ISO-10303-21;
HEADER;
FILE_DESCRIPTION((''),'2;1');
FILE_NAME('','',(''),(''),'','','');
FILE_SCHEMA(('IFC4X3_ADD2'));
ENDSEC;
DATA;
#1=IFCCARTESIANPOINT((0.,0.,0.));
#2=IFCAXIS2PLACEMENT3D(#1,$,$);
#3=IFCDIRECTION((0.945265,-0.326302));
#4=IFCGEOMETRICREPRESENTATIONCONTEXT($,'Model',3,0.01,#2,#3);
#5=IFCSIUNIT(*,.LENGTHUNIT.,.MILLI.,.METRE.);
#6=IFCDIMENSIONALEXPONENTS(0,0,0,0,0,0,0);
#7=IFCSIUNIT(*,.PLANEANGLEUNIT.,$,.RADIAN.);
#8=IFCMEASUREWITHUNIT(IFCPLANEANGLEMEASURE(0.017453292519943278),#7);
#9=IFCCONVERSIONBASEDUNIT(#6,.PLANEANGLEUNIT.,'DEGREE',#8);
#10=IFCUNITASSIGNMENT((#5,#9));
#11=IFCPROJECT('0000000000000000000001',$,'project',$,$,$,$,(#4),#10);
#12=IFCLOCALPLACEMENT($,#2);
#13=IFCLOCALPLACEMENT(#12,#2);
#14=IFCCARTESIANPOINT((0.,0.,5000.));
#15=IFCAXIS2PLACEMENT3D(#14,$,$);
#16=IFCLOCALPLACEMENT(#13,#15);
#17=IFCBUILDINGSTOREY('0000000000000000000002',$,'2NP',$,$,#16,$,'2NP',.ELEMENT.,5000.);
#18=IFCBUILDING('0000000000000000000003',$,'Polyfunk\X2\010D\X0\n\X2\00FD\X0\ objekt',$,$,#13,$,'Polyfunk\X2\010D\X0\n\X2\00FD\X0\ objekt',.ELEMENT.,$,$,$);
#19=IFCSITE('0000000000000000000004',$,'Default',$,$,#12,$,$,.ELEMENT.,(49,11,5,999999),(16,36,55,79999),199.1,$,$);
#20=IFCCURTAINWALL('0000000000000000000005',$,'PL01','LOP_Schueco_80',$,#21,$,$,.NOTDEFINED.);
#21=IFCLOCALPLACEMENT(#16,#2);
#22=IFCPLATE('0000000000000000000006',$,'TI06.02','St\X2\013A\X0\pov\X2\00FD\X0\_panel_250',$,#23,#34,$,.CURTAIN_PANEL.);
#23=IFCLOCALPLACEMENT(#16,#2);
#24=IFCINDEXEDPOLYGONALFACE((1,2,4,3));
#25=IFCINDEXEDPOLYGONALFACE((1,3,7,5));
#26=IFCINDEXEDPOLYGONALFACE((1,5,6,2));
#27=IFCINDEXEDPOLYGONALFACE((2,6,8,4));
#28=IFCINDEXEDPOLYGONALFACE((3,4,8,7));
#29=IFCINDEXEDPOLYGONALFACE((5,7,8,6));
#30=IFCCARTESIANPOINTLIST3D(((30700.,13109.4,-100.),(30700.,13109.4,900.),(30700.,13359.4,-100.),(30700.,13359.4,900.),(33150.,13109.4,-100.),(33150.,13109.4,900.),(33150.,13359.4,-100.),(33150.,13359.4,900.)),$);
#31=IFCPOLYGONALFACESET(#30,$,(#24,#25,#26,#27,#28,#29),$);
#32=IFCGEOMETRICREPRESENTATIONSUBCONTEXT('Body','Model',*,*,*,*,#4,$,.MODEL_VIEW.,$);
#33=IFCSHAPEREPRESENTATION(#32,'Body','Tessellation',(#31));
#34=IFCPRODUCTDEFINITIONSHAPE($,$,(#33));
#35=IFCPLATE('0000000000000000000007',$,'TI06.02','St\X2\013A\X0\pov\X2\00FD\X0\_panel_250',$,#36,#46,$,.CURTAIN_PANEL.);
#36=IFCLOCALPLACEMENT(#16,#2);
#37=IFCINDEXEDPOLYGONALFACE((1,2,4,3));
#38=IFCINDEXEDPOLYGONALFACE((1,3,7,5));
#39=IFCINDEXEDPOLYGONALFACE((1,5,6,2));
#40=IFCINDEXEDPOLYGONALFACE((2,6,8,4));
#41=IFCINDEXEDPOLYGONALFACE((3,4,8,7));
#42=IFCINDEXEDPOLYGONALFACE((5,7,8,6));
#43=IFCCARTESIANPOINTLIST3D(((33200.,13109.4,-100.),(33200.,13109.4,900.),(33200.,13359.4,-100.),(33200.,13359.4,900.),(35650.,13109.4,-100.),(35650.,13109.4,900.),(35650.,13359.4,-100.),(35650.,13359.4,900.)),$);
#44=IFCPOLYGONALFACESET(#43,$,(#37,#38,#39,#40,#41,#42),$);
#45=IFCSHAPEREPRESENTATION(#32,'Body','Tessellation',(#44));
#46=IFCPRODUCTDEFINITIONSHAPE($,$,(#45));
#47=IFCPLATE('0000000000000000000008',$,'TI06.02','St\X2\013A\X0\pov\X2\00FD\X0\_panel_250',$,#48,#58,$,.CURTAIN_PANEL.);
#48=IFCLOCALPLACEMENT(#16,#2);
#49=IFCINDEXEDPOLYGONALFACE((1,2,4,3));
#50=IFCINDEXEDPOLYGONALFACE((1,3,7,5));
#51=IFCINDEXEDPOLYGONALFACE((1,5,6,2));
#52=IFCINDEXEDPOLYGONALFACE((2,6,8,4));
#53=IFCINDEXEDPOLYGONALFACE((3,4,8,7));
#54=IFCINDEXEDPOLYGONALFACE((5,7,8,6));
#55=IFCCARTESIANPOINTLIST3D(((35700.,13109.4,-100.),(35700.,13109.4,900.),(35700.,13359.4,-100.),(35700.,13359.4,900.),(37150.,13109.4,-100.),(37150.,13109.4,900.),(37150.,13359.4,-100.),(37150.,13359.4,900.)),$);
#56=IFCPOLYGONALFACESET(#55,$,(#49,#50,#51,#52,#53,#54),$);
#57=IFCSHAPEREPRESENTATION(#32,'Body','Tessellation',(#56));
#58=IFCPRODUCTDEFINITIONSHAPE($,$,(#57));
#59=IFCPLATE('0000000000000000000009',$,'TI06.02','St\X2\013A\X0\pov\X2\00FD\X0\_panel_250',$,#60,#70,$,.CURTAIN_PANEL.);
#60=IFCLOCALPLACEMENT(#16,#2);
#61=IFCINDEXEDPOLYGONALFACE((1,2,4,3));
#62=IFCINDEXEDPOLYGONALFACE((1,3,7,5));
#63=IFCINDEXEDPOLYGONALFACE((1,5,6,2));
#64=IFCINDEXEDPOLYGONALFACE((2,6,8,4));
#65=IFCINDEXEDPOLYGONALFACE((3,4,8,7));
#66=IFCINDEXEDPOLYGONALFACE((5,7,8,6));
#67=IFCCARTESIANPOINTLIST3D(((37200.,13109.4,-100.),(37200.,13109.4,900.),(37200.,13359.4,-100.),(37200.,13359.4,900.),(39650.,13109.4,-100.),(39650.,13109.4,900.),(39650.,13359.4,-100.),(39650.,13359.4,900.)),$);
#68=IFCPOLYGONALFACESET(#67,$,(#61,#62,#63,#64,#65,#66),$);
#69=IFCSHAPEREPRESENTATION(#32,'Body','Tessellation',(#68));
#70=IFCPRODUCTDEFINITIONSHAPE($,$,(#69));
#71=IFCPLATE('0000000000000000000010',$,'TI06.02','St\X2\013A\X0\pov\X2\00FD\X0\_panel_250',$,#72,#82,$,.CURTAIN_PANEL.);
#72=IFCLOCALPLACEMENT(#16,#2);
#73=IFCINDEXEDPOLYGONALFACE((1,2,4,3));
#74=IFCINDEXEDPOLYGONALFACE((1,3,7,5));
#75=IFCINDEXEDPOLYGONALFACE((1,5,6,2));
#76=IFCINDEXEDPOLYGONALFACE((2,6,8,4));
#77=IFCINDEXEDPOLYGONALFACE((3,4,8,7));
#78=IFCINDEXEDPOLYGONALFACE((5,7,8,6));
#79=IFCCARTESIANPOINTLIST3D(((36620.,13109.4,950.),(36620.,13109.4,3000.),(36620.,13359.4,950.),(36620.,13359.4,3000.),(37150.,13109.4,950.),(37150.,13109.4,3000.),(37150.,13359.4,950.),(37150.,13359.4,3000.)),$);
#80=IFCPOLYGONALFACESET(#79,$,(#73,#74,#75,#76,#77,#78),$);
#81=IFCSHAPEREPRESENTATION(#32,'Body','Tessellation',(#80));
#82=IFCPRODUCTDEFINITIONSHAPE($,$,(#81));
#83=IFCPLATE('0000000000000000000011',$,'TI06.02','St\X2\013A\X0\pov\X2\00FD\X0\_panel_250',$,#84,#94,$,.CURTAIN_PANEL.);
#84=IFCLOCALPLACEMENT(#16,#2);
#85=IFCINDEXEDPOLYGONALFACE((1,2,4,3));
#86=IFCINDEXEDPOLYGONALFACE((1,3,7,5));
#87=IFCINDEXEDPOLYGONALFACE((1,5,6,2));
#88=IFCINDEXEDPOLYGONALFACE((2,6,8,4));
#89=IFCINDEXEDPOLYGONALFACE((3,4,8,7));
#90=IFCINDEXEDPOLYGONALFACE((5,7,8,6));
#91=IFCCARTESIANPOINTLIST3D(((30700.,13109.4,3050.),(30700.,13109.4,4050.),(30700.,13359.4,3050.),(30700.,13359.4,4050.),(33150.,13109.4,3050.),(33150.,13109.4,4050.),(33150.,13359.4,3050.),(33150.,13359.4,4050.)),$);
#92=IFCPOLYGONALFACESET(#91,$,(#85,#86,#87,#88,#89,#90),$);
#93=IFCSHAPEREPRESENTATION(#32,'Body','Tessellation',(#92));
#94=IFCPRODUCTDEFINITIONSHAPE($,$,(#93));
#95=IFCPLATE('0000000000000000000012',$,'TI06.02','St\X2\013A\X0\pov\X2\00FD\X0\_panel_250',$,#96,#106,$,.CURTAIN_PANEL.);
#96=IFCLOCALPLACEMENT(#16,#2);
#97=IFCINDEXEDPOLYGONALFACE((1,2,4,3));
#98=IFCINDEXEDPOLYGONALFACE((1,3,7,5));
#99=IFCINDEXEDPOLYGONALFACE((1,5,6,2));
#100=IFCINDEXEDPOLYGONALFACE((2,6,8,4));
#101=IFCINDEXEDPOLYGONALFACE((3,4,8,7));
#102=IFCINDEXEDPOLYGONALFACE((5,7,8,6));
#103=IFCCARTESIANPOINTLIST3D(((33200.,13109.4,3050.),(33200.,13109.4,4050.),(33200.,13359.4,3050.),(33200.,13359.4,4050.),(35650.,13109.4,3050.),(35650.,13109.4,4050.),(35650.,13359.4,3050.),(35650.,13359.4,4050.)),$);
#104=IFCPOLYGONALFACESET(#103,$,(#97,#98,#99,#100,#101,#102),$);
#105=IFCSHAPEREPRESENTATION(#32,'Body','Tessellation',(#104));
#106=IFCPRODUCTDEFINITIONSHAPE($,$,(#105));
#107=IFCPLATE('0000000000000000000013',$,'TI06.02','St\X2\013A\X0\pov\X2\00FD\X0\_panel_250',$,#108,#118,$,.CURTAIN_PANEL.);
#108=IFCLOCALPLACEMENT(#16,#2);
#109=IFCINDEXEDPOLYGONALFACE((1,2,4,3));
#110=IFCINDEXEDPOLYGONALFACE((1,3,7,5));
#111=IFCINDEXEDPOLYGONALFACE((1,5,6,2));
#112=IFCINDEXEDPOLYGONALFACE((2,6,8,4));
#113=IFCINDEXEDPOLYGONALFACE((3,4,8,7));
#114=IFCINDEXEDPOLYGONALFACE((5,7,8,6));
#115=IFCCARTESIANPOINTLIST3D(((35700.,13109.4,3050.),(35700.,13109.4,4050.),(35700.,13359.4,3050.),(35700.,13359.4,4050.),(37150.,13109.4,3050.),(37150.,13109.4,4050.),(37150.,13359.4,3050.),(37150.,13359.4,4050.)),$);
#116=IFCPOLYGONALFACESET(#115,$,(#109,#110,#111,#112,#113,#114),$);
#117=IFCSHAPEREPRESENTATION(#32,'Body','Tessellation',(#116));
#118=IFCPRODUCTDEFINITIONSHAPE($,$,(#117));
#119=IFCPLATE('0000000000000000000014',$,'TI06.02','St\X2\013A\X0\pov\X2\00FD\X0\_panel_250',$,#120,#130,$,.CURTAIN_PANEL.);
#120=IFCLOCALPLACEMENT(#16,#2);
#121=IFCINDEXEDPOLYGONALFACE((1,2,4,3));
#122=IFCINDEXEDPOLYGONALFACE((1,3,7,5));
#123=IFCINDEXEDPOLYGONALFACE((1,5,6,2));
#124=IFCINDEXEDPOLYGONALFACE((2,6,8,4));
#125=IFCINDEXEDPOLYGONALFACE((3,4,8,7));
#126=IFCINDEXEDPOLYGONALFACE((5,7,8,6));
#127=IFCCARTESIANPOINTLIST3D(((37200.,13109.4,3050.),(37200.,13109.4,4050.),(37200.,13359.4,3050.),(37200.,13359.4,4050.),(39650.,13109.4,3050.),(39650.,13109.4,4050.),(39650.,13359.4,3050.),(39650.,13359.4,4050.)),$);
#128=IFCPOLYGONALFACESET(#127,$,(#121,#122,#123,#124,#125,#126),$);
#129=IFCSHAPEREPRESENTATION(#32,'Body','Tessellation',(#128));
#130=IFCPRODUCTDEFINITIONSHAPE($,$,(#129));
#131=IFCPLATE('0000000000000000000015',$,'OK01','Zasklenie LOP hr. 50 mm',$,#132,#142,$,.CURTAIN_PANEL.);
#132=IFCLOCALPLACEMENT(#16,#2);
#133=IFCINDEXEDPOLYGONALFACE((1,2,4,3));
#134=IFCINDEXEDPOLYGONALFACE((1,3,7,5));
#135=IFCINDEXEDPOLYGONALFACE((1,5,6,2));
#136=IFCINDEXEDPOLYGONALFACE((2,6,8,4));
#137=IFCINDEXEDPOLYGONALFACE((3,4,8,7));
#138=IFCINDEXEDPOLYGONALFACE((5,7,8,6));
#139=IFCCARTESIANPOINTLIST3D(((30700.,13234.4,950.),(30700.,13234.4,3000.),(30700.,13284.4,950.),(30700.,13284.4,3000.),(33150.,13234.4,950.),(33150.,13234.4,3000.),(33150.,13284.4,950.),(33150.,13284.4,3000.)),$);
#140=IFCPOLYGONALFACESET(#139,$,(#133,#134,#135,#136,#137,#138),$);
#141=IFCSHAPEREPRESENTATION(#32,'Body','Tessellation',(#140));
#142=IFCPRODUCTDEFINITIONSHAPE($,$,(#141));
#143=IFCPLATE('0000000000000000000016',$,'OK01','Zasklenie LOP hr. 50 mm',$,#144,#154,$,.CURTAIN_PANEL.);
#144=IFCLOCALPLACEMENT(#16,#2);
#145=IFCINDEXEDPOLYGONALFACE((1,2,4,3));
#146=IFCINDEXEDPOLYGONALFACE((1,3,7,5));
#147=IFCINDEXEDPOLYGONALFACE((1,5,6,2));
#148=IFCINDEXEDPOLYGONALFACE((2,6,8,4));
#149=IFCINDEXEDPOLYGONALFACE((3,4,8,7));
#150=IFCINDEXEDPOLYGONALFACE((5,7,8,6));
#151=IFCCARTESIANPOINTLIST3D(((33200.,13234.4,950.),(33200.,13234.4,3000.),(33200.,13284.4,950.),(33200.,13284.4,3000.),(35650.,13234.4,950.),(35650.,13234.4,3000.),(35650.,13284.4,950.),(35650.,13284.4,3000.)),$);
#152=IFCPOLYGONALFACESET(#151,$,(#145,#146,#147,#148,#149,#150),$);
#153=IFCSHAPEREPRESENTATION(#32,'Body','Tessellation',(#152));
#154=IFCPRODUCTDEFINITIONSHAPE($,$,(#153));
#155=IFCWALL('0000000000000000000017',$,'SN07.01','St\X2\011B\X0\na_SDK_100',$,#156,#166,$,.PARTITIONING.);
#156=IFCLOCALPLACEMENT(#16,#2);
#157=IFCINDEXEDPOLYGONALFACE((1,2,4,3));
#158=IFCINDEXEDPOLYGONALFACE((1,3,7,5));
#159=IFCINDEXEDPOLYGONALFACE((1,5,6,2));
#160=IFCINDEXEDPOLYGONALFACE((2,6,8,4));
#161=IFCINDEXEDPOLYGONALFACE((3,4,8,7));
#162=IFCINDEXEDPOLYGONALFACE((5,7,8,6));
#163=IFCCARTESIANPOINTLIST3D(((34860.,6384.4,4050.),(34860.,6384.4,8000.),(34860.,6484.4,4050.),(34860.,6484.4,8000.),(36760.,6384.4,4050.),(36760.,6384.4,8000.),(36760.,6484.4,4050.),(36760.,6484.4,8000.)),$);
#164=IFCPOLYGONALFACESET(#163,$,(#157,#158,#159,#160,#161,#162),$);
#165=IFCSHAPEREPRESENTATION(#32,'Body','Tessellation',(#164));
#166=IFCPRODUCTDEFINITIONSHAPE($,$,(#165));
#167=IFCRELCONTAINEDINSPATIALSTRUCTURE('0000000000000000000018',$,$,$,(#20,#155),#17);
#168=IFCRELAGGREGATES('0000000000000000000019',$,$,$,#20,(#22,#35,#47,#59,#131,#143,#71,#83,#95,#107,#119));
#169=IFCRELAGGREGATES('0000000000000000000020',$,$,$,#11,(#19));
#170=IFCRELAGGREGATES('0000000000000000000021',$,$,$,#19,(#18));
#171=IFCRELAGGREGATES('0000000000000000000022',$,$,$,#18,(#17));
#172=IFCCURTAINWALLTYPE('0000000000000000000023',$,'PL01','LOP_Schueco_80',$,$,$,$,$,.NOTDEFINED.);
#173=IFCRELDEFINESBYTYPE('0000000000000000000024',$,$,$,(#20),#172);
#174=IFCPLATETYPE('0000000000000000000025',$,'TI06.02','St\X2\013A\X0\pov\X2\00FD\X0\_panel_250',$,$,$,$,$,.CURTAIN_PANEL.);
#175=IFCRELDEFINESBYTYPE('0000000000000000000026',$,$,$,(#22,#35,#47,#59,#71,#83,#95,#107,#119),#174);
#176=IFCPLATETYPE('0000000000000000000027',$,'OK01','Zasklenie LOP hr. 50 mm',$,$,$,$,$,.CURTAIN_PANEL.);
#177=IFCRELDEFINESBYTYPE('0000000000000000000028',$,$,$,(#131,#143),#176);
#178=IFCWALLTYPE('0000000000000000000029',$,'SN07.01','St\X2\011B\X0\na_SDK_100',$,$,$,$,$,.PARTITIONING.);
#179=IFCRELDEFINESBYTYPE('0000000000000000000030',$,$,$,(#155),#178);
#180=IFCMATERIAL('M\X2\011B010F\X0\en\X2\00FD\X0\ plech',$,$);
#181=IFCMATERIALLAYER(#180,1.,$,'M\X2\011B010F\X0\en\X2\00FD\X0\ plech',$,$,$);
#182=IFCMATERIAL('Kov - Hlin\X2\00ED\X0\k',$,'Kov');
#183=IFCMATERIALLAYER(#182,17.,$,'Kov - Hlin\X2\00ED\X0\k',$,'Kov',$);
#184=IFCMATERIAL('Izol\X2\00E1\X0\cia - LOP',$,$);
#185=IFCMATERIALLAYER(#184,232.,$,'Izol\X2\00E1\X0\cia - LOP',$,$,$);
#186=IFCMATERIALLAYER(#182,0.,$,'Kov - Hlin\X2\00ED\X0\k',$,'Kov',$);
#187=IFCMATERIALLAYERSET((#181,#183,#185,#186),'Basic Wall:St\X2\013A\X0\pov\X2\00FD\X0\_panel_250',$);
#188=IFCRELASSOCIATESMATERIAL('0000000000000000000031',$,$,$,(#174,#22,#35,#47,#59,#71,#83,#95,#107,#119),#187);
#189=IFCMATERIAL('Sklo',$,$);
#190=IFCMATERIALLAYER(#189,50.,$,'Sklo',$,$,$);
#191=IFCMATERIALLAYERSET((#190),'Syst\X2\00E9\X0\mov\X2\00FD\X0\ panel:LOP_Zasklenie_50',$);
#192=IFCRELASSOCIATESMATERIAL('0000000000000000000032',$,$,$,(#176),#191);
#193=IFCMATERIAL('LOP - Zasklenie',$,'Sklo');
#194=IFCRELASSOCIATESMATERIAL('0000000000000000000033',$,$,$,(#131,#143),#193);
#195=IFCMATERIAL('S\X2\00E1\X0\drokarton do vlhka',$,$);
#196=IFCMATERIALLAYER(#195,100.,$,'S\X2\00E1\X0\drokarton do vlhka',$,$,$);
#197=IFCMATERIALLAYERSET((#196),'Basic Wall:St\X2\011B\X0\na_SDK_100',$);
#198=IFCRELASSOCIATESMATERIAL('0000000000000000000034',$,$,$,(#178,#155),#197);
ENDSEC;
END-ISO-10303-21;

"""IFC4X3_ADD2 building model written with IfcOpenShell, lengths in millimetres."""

from ifc_helpers import new_model, entity, si_unit, converted_unit, direction, frame, frame_2d, origin, origin_2d_with_axis, place, context, subcontext, project, spatial, polyline, rectangle, extrude, clip, bounded_halfspace, source, transform, mapped, material, layer, layer_set, layer_usage, type_object, type_shapes, element, aggregate, save


model = new_model("IFC4X3_ADD2")

# Units and contexts
model_context = context("Model", 3, precision=0.01, world=origin(), true_north=direction((0.945265, -0.326302)))
body_context = subcontext(model_context, "Body", "Model", "MODEL_VIEW")
ifc_project = project(units=[si_unit("LENGTHUNIT", "METRE", prefix="MILLI"), converted_unit("PLANEANGLEUNIT", "DEGREE", entity("IfcPlaneAngleMeasure", 0.017453292519943278), si_unit("PLANEANGLEUNIT", "RADIAN"), dimensions=[0, 0, 0, 0, 0, 0, 0])], contexts=[model_context])

# Site, building, storey
site_placement = place(None, origin())
site = spatial("IfcSite", under=ifc_project, at=site_placement, Name="Default", CompositionType="ELEMENT", RefLatitude=(49, 11, 5, 999999), RefLongitude=(16, 36, 55, 79999), RefElevation=199.1)
building_placement = place(site_placement, origin())
building = spatial("IfcBuilding", under=site, at=building_placement, Name="Polyfunkčný objekt", LongName="Polyfunkčný objekt", CompositionType="ELEMENT")
storey_placement = place(building_placement, frame((0.0, 0.0, 5000.0)))
storey = spatial("IfcBuildingStorey", under=building, at=storey_placement, Name="2NP", LongName="2NP", CompositionType="ELEMENT", Elevation=5000.0)

# Curtain wall, plates
curtain_wall_type = type_object("IfcCurtainWallType", Name="PL01", Description="LOP_Schueco_80", PredefinedType="NOTDEFINED")
curtain_wall_placement = place(storey_placement, frame((0.0, 0.0, -5000.0)))
curtain_wall = element("IfcCurtainWall", 1, at=curtain_wall_placement, inside=storey, type_object=curtain_wall_type, Name="PL01", Description="LOP_Schueco_80", PredefinedType="NOTDEFINED")
ifc_material_1 = material(Name="Měďený plech")
ifc_layer_1 = layer(ifc_material_1, 1.0, Name="Měďený plech")
ifc_material_2 = material(Name="Kov - Hliník", Category="Kov")
ifc_layer_2 = layer(ifc_material_2, 17.0, Name="Kov - Hliník", Category="Kov")
ifc_material_3 = material(Name="Izolácia - LOP")
ifc_layer_3 = layer(ifc_material_3, 232.0, Name="Izolácia - LOP")
ifc_layer_4 = layer(ifc_material_2, 0.0, Name="Kov - Hliník", Category="Kov")
ifc_layer_set_1 = layer_set([ifc_layer_1, ifc_layer_2, ifc_layer_3, ifc_layer_4], Name="Basic Wall:Stĺpový_panel_250")
ifc_layer_usage_1 = layer_usage(ifc_layer_set_1, "AXIS2", "NEGATIVE", 125.0)
plate_type_1 = type_object("IfcPlateType", Name="TI06.02", Description="Stĺpový_panel_250", PredefinedType="CURTAIN_PANEL", material=ifc_layer_set_1)
plate_1_placement = place(storey_placement, frame((30700.0, 13234.4, -100.0)))
plate_1 = element("IfcPlate", 2, at=plate_1_placement, type_object=plate_type_1, material=ifc_layer_usage_1, Name="TI06.02", Description="Stĺpový_panel_250", PredefinedType="CURTAIN_PANEL", context=body_context, shape_type="SweptSolid", body=[
    extrude(rectangle(XDim=250.0, YDim=2450.0, at=frame_2d((0.0, 0.0), x_axis=(1.0, 0.0))), frame((1225.0, 0.0, 0.0), z_axis=(0.0, 0.0, 1.0), x_axis=(0.0, 1.0, 0.0)), (0.0, 0.0, 1.0), 1000.0),
])
ifc_layer_usage_2 = layer_usage(ifc_layer_set_1, "AXIS2", "NEGATIVE", 125.0)
plate_2_placement = place(storey_placement, frame((33200.0, 13234.4, -100.0)))
plate_2 = element("IfcPlate", 3, at=plate_2_placement, type_object=plate_type_1, material=ifc_layer_usage_2, Name="TI06.02", Description="Stĺpový_panel_250", PredefinedType="CURTAIN_PANEL", context=body_context, shape_type="SweptSolid", body=[
    extrude(rectangle(XDim=250.0, YDim=2450.0, at=frame_2d((0.0, 0.0), x_axis=(1.0, 0.0))), frame((1225.0, 0.0, 0.0), z_axis=(0.0, 0.0, 1.0), x_axis=(0.0, 1.0, 0.0)), (0.0, 0.0, 1.0), 1000.0),
])
ifc_layer_usage_3 = layer_usage(ifc_layer_set_1, "AXIS2", "NEGATIVE", 125.0)
plate_3_placement = place(storey_placement, frame((35700.0, 13234.4, -100.0)))
plate_3 = element("IfcPlate", 4, at=plate_3_placement, type_object=plate_type_1, material=ifc_layer_usage_3, Name="TI06.02", Description="Stĺpový_panel_250", PredefinedType="CURTAIN_PANEL", context=body_context, shape_type="SweptSolid", body=[
    extrude(rectangle(XDim=250.0, YDim=1450.0, at=origin_2d_with_axis()), frame((725.0, 0.0, 0.0), z_axis=(0.0, 0.0, 1.0), x_axis=(0.0, 1.0, 0.0)), (0.0, 0.0, 1.0), 1000.0),
])
ifc_layer_usage_4 = layer_usage(ifc_layer_set_1, "AXIS2", "NEGATIVE", 125.0)
plate_4_placement = place(storey_placement, frame((37200.0, 13234.4, -100.0)))
plate_4 = element("IfcPlate", 5, at=plate_4_placement, type_object=plate_type_1, material=ifc_layer_usage_4, Name="TI06.02", Description="Stĺpový_panel_250", PredefinedType="CURTAIN_PANEL", context=body_context, shape_type="SweptSolid", body=[
    extrude(rectangle(XDim=250.0, YDim=2450.0, at=frame_2d((0.0, 0.0), x_axis=(1.0, 0.0))), frame((1225.0, 0.0, 0.0), z_axis=(0.0, 0.0, 1.0), x_axis=(0.0, 1.0, 0.0)), (0.0, 0.0, 1.0), 1000.0),
])
ifc_layer_usage_5 = layer_usage(ifc_layer_set_1, "AXIS2", "NEGATIVE", 125.0)
plate_5_placement = place(storey_placement, frame((36620.0, 13234.4, 950.0)))
plate_5 = element("IfcPlate", 6, at=plate_5_placement, type_object=plate_type_1, material=ifc_layer_usage_5, Name="TI06.02", Description="Stĺpový_panel_250", PredefinedType="CURTAIN_PANEL", context=body_context, shape_type="SweptSolid", body=[
    extrude(rectangle(XDim=250.0, YDim=530.0, at=frame_2d((0.0, 0.0), x_axis=(1.0, 0.0))), frame((265.0, 0.0, 0.0), z_axis=(0.0, 0.0, 1.0), x_axis=(0.0, 1.0, 0.0)), (0.0, 0.0, 1.0), 2050.0),
])
ifc_layer_usage_6 = layer_usage(ifc_layer_set_1, "AXIS2", "NEGATIVE", 125.0)
plate_6_placement = place(storey_placement, frame((30700.0, 13234.4, 3050.0)))
plate_6 = element("IfcPlate", 7, at=plate_6_placement, type_object=plate_type_1, material=ifc_layer_usage_6, Name="TI06.02", Description="Stĺpový_panel_250", PredefinedType="CURTAIN_PANEL", context=body_context, shape_type="SweptSolid", body=[
    extrude(rectangle(XDim=250.0, YDim=2450.0, at=frame_2d((0.0, 0.0), x_axis=(1.0, 0.0))), frame((1225.0, 0.0, 0.0), z_axis=(0.0, 0.0, 1.0), x_axis=(0.0, 1.0, 0.0)), (0.0, 0.0, 1.0), 1000.0),
])
ifc_layer_usage_7 = layer_usage(ifc_layer_set_1, "AXIS2", "NEGATIVE", 125.0)
plate_7_placement = place(storey_placement, frame((33200.0, 13234.4, 3050.0)))
plate_7 = element("IfcPlate", 8, at=plate_7_placement, type_object=plate_type_1, material=ifc_layer_usage_7, Name="TI06.02", Description="Stĺpový_panel_250", PredefinedType="CURTAIN_PANEL", context=body_context, shape_type="SweptSolid", body=[
    extrude(rectangle(XDim=250.0, YDim=2450.0, at=frame_2d((0.0, 0.0), x_axis=(1.0, 0.0))), frame((1225.0, 0.0, 0.0), z_axis=(0.0, 0.0, 1.0), x_axis=(0.0, 1.0, 0.0)), (0.0, 0.0, 1.0), 1000.0),
])
ifc_layer_usage_8 = layer_usage(ifc_layer_set_1, "AXIS2", "NEGATIVE", 125.0)
plate_8_placement = place(storey_placement, frame((35700.0, 13234.4, 3050.0)))
plate_8 = element("IfcPlate", 9, at=plate_8_placement, type_object=plate_type_1, material=ifc_layer_usage_8, Name="TI06.02", Description="Stĺpový_panel_250", PredefinedType="CURTAIN_PANEL", context=body_context, shape_type="SweptSolid", body=[
    extrude(rectangle(XDim=250.0, YDim=1450.0, at=origin_2d_with_axis()), frame((725.0, 0.0, 0.0), z_axis=(0.0, 0.0, 1.0), x_axis=(0.0, 1.0, 0.0)), (0.0, 0.0, 1.0), 1000.0),
])
ifc_layer_usage_9 = layer_usage(ifc_layer_set_1, "AXIS2", "NEGATIVE", 125.0)
plate_9_placement = place(storey_placement, frame((37200.0, 13234.4, 3050.0)))
plate_9 = element("IfcPlate", 10, at=plate_9_placement, type_object=plate_type_1, material=ifc_layer_usage_9, Name="TI06.02", Description="Stĺpový_panel_250", PredefinedType="CURTAIN_PANEL", context=body_context, shape_type="SweptSolid", body=[
    extrude(rectangle(XDim=250.0, YDim=2450.0, at=frame_2d((0.0, 0.0), x_axis=(1.0, 0.0))), frame((1225.0, 0.0, 0.0), z_axis=(0.0, 0.0, 1.0), x_axis=(0.0, 1.0, 0.0)), (0.0, 0.0, 1.0), 1000.0),
])
ifc_material_4 = material(Name="LOP - Zasklenie", Category="Sklo")
ifc_material_5 = material(Name="Sklo")
ifc_layer_5 = layer(ifc_material_5, 50.0, Name="Sklo")
ifc_layer_set_2 = layer_set([ifc_layer_5], Name="Systémový panel:LOP_Zasklenie_50")
plate_type_2 = type_object("IfcPlateType", Name="OK01", Description="Zasklenie LOP hr. 50 mm", PredefinedType="CURTAIN_PANEL", material=ifc_layer_set_2)
shared_shape_1 = source(origin(), body_context, "Body", "SweptSolid", [
    extrude(rectangle(XDim=50.0, YDim=2450.0, at=origin_2d_with_axis()), frame((0.0, 25.0, 0.0), z_axis=(0.0, 0.0, 1.0), x_axis=(0.0, 1.0, 0.0)), (0.0, 0.0, 1.0), 2050.0),
])
type_shapes(plate_type_2, [shared_shape_1])
plate_10_placement = place(curtain_wall_placement, frame((31925.0, 13234.4, 5950.0)))
plate_10 = element("IfcPlate", 11, at=plate_10_placement, type_object=plate_type_2, material=ifc_material_4, Name="OK01", Description="Zasklenie LOP hr. 50 mm", PredefinedType="CURTAIN_PANEL", context=body_context, shape_type="MappedRepresentation", body=[
    mapped(shared_shape_1, transform((0.0, 0.0, 0.0), scale=1.0)),
])
plate_11_placement = place(curtain_wall_placement, frame((34425.0, 13234.4, 5950.0)))
plate_11 = element("IfcPlate", 12, at=plate_11_placement, type_object=plate_type_2, material=ifc_material_4, Name="OK01", Description="Zasklenie LOP hr. 50 mm", PredefinedType="CURTAIN_PANEL", context=body_context, shape_type="MappedRepresentation", body=[
    mapped(shared_shape_1, transform((0.0, 0.0, 0.0), scale=1.0)),
])

# Wall
ifc_material_6 = material(Name="Sádrokarton do vlhka")
ifc_layer_6 = layer(ifc_material_6, 100.0, Name="Sádrokarton do vlhka")
ifc_layer_set_3 = layer_set([ifc_layer_6], Name="Basic Wall:Stěna_SDK_100")
wall_type_1 = type_object("IfcWallType", Name="SN07.01", Description="Stěna_SDK_100", PredefinedType="PARTITIONING", material=ifc_layer_set_3)
wall_1_placement = place(storey_placement, frame((36760.0, 6434.4, 4050.0), z_axis=(0.0, 0.0, 1.0), x_axis=(-1.0, 0.0, 0.0)))
element("IfcWall", 13, at=wall_1_placement, inside=storey, type_object=wall_type_1, material=ifc_layer_set_3, Name="SN07.01", Description="Stěna_SDK_100", PredefinedType="PARTITIONING", context=body_context, shape_type="Clipping", body=[
    clip(clip(extrude(rectangle(XDim=1900.0, YDim=100.0, at=frame_2d((950.0, 0.0), x_axis=(-1.0, 0.0))), origin(), (0.0, 0.0, 1.0), 3950.0), bounded_halfspace(frame((1900.0, -50.0, 0.0)), True, frame((1900.0, -50.0, 0.0)), polyline([(0.0, 0.0), (0.0, 100.0), (-1750.0, 100.0), (-1900.0, 100.0), (-1900.0, 0.0), (0.0, 0.0)]))), bounded_halfspace(frame((0.0, -50.0, 3950.0), z_axis=(0.0, 0.0, -1.0), x_axis=(-1.0, 0.0, 0.0)), True, frame((0.0, -50.0, 3950.0)), polyline([(0.0, 0.0), (1900.0, 0.0), (1900.0, 100.0), (150.0, 100.0), (0.0, 100.0), (0.0, 0.0)]))),
])

aggregate(curtain_wall, [plate_1, plate_2, plate_3, plate_4, plate_10, plate_11, plate_5, plate_6, plate_7, plate_8, plate_9])

save(model, "model.ifc")
